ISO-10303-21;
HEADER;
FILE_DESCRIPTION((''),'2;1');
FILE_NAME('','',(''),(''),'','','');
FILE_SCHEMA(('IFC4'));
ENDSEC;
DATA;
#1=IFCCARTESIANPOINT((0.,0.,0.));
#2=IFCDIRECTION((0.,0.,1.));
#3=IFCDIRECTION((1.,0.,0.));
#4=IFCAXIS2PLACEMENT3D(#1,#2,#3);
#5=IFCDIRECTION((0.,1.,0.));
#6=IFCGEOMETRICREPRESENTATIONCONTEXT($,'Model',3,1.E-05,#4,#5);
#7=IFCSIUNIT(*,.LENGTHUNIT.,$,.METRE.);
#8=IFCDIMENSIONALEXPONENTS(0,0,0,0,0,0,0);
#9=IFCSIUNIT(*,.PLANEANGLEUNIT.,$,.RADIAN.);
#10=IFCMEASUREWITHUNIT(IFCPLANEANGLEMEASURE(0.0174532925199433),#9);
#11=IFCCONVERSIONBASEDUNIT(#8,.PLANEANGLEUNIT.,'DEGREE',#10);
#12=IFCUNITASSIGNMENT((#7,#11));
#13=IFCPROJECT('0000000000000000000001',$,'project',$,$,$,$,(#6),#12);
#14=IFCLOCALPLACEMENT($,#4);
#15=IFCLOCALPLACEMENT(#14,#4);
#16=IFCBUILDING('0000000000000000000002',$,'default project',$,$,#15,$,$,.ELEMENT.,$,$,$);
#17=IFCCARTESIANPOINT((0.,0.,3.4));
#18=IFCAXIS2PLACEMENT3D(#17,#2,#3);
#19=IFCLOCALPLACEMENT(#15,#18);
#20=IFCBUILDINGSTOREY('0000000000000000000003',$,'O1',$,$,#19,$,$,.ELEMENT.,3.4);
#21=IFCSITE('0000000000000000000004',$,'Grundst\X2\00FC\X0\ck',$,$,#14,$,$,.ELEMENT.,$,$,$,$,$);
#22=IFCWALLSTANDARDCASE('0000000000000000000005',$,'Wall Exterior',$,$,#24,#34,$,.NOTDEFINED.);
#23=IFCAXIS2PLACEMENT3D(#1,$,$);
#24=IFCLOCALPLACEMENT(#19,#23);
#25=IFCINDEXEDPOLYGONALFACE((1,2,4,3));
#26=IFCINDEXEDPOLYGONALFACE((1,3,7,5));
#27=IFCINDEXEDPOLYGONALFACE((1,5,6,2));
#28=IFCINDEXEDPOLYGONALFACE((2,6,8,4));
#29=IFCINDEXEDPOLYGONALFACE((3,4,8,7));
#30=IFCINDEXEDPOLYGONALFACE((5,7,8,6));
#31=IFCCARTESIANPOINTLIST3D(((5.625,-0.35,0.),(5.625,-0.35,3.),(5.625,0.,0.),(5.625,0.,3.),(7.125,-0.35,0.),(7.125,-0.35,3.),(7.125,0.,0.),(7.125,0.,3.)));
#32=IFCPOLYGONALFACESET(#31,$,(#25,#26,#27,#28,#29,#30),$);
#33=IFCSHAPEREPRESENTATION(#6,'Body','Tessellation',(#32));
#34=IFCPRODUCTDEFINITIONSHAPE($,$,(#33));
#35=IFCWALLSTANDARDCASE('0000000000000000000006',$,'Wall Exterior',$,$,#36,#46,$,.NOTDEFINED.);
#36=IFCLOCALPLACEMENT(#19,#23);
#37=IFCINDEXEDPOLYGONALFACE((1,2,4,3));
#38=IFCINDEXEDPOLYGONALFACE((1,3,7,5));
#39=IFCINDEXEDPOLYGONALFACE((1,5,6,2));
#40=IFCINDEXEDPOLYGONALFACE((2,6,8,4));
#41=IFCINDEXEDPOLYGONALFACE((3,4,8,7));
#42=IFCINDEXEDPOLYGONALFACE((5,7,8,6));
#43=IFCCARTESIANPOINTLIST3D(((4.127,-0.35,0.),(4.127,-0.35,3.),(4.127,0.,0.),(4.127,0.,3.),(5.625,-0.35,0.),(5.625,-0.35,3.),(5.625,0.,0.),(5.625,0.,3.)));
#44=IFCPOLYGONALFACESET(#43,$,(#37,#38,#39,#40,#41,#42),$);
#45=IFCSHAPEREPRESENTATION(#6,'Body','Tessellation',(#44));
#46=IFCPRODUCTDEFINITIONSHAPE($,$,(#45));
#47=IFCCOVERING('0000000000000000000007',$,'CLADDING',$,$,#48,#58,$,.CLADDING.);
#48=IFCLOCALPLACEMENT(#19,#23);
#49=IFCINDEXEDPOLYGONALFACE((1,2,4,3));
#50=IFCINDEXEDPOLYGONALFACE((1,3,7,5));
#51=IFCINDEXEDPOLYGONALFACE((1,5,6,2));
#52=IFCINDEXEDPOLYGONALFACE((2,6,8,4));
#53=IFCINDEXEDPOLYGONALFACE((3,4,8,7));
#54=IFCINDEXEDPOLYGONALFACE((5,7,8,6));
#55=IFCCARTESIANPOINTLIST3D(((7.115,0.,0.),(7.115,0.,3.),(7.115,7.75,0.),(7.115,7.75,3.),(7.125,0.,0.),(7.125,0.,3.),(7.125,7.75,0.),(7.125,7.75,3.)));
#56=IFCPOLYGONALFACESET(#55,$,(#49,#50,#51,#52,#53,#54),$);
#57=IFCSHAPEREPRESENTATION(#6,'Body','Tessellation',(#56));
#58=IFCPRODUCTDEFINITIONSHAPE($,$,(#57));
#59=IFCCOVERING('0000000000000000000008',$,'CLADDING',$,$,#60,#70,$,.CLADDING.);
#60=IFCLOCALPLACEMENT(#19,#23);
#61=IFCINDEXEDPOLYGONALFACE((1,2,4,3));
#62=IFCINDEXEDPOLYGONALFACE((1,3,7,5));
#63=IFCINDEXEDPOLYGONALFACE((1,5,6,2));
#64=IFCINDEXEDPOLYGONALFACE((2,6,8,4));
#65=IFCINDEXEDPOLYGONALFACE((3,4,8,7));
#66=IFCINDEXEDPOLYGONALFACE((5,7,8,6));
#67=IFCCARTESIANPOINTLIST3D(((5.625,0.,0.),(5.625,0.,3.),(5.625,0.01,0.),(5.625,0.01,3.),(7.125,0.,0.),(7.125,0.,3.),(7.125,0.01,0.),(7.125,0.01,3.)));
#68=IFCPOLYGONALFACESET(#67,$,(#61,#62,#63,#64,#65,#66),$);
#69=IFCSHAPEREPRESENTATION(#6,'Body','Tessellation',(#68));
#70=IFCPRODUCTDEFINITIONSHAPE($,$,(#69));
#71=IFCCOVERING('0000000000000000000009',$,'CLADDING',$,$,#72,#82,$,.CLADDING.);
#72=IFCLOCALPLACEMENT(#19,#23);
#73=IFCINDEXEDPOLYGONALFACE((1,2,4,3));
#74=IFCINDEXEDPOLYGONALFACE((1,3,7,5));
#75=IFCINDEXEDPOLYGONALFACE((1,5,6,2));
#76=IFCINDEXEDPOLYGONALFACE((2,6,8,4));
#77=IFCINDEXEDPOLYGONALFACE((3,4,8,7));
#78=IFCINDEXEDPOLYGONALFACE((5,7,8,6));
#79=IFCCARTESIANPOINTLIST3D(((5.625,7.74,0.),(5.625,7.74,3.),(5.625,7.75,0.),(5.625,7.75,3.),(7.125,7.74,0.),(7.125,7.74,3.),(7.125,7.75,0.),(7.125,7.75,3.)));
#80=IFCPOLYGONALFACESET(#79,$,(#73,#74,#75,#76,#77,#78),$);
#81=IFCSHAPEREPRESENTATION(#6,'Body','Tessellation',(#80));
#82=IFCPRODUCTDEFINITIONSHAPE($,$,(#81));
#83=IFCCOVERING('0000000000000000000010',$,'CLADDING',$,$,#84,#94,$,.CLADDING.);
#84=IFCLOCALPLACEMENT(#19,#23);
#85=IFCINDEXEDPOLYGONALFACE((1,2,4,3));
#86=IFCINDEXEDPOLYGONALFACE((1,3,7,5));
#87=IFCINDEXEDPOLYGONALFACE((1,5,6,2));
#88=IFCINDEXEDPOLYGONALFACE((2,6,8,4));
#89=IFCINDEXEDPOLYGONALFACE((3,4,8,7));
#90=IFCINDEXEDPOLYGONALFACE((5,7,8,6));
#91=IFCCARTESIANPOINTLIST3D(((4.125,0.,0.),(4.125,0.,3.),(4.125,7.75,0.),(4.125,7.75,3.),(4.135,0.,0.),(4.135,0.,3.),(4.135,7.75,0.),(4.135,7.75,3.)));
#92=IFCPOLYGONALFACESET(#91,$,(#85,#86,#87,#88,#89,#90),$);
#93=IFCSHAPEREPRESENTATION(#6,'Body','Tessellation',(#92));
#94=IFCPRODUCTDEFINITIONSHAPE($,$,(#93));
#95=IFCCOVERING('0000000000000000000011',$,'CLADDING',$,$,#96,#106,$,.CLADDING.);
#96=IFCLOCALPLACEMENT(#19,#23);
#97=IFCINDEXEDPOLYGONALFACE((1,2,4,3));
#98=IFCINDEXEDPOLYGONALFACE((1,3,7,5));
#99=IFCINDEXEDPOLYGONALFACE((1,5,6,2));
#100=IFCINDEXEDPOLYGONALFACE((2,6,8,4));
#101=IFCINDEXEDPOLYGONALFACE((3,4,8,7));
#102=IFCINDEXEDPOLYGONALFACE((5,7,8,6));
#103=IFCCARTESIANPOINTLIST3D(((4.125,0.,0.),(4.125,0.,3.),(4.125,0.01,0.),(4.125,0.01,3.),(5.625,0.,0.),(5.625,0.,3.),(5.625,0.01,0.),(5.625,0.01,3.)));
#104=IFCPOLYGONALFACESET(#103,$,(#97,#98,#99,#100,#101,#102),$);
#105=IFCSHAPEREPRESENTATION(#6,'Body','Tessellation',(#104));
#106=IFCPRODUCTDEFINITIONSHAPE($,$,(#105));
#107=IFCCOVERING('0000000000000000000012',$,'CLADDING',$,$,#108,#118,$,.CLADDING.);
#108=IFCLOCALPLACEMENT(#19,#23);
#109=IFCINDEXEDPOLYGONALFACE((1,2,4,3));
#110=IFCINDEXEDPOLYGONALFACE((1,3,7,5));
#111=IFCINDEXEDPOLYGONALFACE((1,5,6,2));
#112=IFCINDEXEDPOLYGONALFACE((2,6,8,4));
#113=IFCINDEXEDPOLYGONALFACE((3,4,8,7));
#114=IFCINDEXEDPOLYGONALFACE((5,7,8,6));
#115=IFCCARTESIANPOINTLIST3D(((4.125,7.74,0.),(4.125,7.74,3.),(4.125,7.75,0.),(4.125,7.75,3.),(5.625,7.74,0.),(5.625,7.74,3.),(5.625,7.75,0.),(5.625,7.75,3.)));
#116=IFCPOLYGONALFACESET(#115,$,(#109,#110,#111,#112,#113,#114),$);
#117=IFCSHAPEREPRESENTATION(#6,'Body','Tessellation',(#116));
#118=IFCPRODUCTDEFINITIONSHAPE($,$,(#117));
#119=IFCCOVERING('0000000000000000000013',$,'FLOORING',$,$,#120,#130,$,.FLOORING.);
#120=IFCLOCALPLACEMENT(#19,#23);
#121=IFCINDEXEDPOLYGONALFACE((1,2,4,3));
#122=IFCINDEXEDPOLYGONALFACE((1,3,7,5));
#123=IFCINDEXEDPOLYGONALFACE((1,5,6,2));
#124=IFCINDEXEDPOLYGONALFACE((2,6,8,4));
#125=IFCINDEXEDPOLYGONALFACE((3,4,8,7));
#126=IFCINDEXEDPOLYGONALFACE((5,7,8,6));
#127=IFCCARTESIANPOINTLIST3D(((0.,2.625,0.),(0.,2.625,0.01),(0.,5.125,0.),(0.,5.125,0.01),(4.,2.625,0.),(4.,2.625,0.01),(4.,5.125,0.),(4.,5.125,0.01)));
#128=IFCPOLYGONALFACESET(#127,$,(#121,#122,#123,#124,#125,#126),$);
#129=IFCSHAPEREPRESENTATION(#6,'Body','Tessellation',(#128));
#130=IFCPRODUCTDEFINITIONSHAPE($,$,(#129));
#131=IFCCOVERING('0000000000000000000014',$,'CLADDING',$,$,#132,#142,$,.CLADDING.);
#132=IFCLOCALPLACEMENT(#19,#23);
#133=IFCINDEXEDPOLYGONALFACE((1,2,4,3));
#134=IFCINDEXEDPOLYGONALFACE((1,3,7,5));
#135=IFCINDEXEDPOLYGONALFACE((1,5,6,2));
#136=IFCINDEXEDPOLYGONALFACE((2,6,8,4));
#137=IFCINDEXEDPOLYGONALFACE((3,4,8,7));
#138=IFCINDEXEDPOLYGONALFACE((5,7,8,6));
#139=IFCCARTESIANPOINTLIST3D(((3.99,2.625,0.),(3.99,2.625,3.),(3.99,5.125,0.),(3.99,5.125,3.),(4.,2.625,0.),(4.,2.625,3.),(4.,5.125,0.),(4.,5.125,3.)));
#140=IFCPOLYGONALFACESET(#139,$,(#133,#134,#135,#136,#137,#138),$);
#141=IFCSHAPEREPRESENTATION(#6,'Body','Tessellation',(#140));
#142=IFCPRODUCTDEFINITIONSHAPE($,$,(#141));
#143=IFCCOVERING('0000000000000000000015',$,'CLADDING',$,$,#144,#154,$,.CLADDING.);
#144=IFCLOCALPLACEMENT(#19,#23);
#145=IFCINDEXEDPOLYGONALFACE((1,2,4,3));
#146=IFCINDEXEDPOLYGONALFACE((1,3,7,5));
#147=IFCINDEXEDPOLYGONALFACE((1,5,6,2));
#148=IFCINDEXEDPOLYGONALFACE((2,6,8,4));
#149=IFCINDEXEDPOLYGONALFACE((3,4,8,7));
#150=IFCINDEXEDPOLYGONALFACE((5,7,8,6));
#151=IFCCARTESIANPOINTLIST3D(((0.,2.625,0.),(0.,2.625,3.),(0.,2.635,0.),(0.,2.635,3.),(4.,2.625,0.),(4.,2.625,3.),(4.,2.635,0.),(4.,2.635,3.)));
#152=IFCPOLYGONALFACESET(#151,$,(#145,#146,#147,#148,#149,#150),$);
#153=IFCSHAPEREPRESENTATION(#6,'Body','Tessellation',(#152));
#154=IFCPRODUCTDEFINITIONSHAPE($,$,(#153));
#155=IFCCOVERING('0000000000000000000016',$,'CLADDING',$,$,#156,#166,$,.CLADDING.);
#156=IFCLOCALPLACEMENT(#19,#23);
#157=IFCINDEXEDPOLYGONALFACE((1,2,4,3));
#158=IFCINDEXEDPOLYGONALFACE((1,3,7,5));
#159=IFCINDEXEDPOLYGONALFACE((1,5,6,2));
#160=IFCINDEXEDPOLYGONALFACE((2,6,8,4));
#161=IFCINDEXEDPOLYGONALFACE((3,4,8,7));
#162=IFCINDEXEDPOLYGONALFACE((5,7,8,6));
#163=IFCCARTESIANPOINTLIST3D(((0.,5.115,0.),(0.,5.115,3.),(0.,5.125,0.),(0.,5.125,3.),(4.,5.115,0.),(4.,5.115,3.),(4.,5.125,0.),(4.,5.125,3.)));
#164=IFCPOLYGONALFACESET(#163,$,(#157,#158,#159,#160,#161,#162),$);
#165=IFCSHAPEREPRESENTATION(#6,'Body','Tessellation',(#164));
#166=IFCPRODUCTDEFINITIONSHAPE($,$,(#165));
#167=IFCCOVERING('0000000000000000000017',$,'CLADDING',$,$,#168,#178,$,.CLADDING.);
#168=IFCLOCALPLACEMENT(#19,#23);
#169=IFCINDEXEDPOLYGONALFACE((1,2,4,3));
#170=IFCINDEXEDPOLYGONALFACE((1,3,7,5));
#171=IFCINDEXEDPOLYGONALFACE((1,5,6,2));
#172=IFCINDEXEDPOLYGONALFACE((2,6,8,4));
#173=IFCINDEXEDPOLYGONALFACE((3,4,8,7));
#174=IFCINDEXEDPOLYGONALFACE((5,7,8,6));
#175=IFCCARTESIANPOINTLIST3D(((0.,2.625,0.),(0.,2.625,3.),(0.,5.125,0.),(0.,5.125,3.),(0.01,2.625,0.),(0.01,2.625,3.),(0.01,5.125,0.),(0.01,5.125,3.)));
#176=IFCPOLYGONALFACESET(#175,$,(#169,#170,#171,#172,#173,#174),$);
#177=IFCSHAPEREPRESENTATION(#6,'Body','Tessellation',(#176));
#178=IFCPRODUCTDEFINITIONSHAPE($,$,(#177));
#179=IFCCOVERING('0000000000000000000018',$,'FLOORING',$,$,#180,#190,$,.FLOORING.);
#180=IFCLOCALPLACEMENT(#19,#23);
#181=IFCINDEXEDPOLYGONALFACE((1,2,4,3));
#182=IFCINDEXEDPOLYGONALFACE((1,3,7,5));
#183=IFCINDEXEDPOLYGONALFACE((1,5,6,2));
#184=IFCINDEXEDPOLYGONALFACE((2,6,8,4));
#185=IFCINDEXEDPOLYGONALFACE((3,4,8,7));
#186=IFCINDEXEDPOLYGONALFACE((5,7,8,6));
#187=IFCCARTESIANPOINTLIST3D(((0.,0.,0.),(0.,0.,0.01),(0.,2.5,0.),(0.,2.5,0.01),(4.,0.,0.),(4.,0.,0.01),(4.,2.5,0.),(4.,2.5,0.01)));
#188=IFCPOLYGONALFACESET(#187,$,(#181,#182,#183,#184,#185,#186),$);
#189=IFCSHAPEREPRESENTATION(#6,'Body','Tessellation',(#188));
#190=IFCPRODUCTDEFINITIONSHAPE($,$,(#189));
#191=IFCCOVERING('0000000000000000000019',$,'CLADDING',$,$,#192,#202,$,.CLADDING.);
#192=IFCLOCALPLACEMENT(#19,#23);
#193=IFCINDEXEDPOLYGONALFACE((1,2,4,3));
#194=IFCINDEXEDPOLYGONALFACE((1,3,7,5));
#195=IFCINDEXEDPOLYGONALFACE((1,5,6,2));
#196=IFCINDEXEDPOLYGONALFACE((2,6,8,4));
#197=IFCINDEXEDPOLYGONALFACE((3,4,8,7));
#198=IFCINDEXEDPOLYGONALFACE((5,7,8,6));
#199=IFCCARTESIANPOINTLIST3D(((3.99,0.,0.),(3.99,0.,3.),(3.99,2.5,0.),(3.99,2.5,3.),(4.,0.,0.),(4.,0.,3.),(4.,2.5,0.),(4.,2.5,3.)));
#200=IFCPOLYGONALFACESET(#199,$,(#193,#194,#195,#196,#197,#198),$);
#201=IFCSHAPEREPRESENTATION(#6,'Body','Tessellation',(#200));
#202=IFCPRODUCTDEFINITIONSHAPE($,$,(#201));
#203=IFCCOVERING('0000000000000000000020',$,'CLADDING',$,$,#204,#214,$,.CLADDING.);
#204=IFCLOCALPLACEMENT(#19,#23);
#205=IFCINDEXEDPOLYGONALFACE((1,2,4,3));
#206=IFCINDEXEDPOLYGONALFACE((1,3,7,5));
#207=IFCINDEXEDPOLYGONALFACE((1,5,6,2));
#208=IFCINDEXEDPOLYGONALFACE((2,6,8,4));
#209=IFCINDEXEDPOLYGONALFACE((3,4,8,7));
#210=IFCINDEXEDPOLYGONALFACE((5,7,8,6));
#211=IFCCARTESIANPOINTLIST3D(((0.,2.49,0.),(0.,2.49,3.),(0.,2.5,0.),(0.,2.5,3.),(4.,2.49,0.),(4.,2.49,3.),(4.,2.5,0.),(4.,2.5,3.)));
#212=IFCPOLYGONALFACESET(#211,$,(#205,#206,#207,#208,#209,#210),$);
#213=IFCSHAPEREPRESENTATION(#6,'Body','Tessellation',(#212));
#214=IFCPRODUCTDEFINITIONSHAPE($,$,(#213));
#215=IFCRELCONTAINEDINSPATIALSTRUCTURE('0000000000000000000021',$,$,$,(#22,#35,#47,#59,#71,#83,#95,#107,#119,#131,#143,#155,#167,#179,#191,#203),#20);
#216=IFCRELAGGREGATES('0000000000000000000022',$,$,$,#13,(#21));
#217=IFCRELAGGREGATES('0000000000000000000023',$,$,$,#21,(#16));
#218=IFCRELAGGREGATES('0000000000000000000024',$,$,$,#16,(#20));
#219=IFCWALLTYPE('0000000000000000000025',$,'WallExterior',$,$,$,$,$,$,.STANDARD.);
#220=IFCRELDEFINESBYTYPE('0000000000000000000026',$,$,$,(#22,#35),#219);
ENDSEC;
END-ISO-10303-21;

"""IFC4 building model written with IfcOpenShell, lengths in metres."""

from ifc_helpers import new_model, entity, si_unit, converted_unit, direction, frame, origin_with_axes, place, context, project, spatial, polyline, outline, extrude, type_object, element, save


model = new_model("IFC4")

# Units and contexts
model_context = context("Model", 3, precision=1e-05, world=origin_with_axes(), true_north=direction((0.0, 1.0, 0.0)))
ifc_project = project(units=[si_unit("LENGTHUNIT", "METRE"), converted_unit("PLANEANGLEUNIT", "DEGREE", entity("IfcPlaneAngleMeasure", 0.0174532925199433), si_unit("PLANEANGLEUNIT", "RADIAN"), dimensions=[0, 0, 0, 0, 0, 0, 0])], contexts=[model_context])

# Site, building, storey
site_placement = place(None, origin_with_axes())
site = spatial("IfcSite", under=ifc_project, at=site_placement, Name="Grundstück", CompositionType="ELEMENT")
building_placement = place(site_placement, origin_with_axes())
building = spatial("IfcBuilding", under=site, at=building_placement, Name="default project", CompositionType="ELEMENT")
placement_1 = place(building_placement, frame((0.0, 0.0, 3.4), z_axis=(0.0, 0.0, 1.0), x_axis=(1.0, 0.0, 0.0)))
storey = spatial("IfcBuildingStorey", under=building, at=placement_1, Name="O1", CompositionType="ELEMENT", Elevation=3.4)

# Walls
wall_type_1 = type_object("IfcWallType", Name="WallExterior", PredefinedType="STANDARD")
placement_2 = place(placement_1, frame((7.3, -0.175, 0.0), z_axis=(0.0, 0.0, 1.0), x_axis=(-1.0, 0.0, 0.0)))
element("IfcWallStandardCase", 1, at=placement_2, inside=storey, type_object=wall_type_1, Name="Wall Exterior", PredefinedType="NOTDEFINED", context=model_context, shape_type="SweptSolid", body=[
    extrude(outline(polyline([(0.175, -0.175), (1.675, -0.175), (1.675, 0.175), (0.175, 0.175), (0.175, -0.175)])), origin_with_axes(), (0.0, 0.0, 1.0), 3.0),
])
placement_3 = place(placement_1, frame((5.625, -0.175, 0.0), z_axis=(0.0, 0.0, 1.0), x_axis=(-1.0, 0.0, 0.0)))
element("IfcWallStandardCase", 2, at=placement_3, inside=storey, type_object=wall_type_1, Name="Wall Exterior", PredefinedType="NOTDEFINED", context=model_context, shape_type="SweptSolid", body=[
    extrude(outline(polyline([(0.0, -0.175), (1.498, -0.175), (1.498, 0.175), (0.0, 0.175), (0.0, -0.175)])), origin_with_axes(), (0.0, 0.0, 1.0), 3.0),
])

# Coverings
element("IfcCovering", 3, at=placement_1, inside=storey, Name="CLADDING", PredefinedType="CLADDING", context=model_context, shape_type="SweptSolid", body=[
    extrude(outline(polyline([(7.115, 7.75), (7.115, 0.0), (7.125, 0.0), (7.125, 7.75), (7.115, 7.75)])), origin_with_axes(), (0.0, 0.0, 1.0), 3.0),
])
element("IfcCovering", 4, at=placement_1, inside=storey, Name="CLADDING", PredefinedType="CLADDING", context=model_context, shape_type="SweptSolid", body=[
    extrude(outline(polyline([(7.125, 0.01), (5.625, 0.01), (5.625, 0.0), (7.125, 0.0), (7.125, 0.01)])), origin_with_axes(), (0.0, 0.0, 1.0), 3.0),
])
element("IfcCovering", 5, at=placement_1, inside=storey, Name="CLADDING", PredefinedType="CLADDING", context=model_context, shape_type="SweptSolid", body=[
    extrude(outline(polyline([(5.625, 7.74), (7.125, 7.74), (7.125, 7.75), (5.625, 7.75), (5.625, 7.74)])), origin_with_axes(), (0.0, 0.0, 1.0), 3.0),
])
element("IfcCovering", 6, at=placement_1, inside=storey, Name="CLADDING", PredefinedType="CLADDING", context=model_context, shape_type="SweptSolid", body=[
    extrude(outline(polyline([(4.135, 0.0), (4.135, 7.75), (4.125, 7.75), (4.125, 0.0), (4.135, 0.0)])), origin_with_axes(), (0.0, 0.0, 1.0), 3.0),
])
element("IfcCovering", 7, at=placement_1, inside=storey, Name="CLADDING", PredefinedType="CLADDING", context=model_context, shape_type="SweptSolid", body=[
    extrude(outline(polyline([(5.625, 0.01), (4.125, 0.01), (4.125, 0.0), (5.625, 0.0), (5.625, 0.01)])), origin_with_axes(), (0.0, 0.0, 1.0), 3.0),
])
element("IfcCovering", 8, at=placement_1, inside=storey, Name="CLADDING", PredefinedType="CLADDING", context=model_context, shape_type="SweptSolid", body=[
    extrude(outline(polyline([(4.125, 7.74), (5.625, 7.74), (5.625, 7.75), (4.125, 7.75), (4.125, 7.74)])), origin_with_axes(), (0.0, 0.0, 1.0), 3.0),
])
element("IfcCovering", 9, at=placement_1, inside=storey, Name="FLOORING", PredefinedType="FLOORING", context=model_context, shape_type="SweptSolid", body=[
    extrude(outline(polyline([(4.0, 5.125), (0.0, 5.125), (0.0, 2.625), (4.0, 2.625), (4.0, 5.125)])), origin_with_axes(), (0.0, 0.0, 1.0), 0.01),
])
element("IfcCovering", 10, at=placement_1, inside=storey, Name="CLADDING", PredefinedType="CLADDING", context=model_context, shape_type="SweptSolid", body=[
    extrude(outline(polyline([(3.99, 5.125), (3.99, 2.625), (4.0, 2.625), (4.0, 5.125), (3.99, 5.125)])), origin_with_axes(), (0.0, 0.0, 1.0), 3.0),
])
element("IfcCovering", 11, at=placement_1, inside=storey, Name="CLADDING", PredefinedType="CLADDING", context=model_context, shape_type="SweptSolid", body=[
    extrude(outline(polyline([(4.0, 2.635), (0.0, 2.635), (0.0, 2.625), (4.0, 2.625), (4.0, 2.635)])), origin_with_axes(), (0.0, 0.0, 1.0), 3.0),
])
element("IfcCovering", 12, at=placement_1, inside=storey, Name="CLADDING", PredefinedType="CLADDING", context=model_context, shape_type="SweptSolid", body=[
    extrude(outline(polyline([(0.0, 5.115), (4.0, 5.115), (4.0, 5.125), (0.0, 5.125), (0.0, 5.115)])), origin_with_axes(), (0.0, 0.0, 1.0), 3.0),
])
element("IfcCovering", 13, at=placement_1, inside=storey, Name="CLADDING", PredefinedType="CLADDING", context=model_context, shape_type="SweptSolid", body=[
    extrude(outline(polyline([(0.01, 2.625), (0.01, 5.125), (0.0, 5.125), (0.0, 2.625), (0.01, 2.625)])), origin_with_axes(), (0.0, 0.0, 1.0), 3.0),
])
element("IfcCovering", 14, at=placement_1, inside=storey, Name="FLOORING", PredefinedType="FLOORING", context=model_context, shape_type="SweptSolid", body=[
    extrude(outline(polyline([(4.0, 2.5), (0.0, 2.5), (0.0, 0.0), (4.0, 0.0), (4.0, 2.5)])), origin_with_axes(), (0.0, 0.0, 1.0), 0.01),
])
element("IfcCovering", 15, at=placement_1, inside=storey, Name="CLADDING", PredefinedType="CLADDING", context=model_context, shape_type="SweptSolid", body=[
    extrude(outline(polyline([(3.99, 2.5), (3.99, 0.0), (4.0, 0.0), (4.0, 2.5), (3.99, 2.5)])), origin_with_axes(), (0.0, 0.0, 1.0), 3.0),
])
element("IfcCovering", 16, at=placement_1, inside=storey, Name="CLADDING", PredefinedType="CLADDING", context=model_context, shape_type="SweptSolid", body=[
    extrude(outline(polyline([(0.0, 2.49), (4.0, 2.49), (4.0, 2.5), (0.0, 2.5), (0.0, 2.49)])), origin_with_axes(), (0.0, 0.0, 1.0), 3.0),
])

save(model, "model.ifc")
